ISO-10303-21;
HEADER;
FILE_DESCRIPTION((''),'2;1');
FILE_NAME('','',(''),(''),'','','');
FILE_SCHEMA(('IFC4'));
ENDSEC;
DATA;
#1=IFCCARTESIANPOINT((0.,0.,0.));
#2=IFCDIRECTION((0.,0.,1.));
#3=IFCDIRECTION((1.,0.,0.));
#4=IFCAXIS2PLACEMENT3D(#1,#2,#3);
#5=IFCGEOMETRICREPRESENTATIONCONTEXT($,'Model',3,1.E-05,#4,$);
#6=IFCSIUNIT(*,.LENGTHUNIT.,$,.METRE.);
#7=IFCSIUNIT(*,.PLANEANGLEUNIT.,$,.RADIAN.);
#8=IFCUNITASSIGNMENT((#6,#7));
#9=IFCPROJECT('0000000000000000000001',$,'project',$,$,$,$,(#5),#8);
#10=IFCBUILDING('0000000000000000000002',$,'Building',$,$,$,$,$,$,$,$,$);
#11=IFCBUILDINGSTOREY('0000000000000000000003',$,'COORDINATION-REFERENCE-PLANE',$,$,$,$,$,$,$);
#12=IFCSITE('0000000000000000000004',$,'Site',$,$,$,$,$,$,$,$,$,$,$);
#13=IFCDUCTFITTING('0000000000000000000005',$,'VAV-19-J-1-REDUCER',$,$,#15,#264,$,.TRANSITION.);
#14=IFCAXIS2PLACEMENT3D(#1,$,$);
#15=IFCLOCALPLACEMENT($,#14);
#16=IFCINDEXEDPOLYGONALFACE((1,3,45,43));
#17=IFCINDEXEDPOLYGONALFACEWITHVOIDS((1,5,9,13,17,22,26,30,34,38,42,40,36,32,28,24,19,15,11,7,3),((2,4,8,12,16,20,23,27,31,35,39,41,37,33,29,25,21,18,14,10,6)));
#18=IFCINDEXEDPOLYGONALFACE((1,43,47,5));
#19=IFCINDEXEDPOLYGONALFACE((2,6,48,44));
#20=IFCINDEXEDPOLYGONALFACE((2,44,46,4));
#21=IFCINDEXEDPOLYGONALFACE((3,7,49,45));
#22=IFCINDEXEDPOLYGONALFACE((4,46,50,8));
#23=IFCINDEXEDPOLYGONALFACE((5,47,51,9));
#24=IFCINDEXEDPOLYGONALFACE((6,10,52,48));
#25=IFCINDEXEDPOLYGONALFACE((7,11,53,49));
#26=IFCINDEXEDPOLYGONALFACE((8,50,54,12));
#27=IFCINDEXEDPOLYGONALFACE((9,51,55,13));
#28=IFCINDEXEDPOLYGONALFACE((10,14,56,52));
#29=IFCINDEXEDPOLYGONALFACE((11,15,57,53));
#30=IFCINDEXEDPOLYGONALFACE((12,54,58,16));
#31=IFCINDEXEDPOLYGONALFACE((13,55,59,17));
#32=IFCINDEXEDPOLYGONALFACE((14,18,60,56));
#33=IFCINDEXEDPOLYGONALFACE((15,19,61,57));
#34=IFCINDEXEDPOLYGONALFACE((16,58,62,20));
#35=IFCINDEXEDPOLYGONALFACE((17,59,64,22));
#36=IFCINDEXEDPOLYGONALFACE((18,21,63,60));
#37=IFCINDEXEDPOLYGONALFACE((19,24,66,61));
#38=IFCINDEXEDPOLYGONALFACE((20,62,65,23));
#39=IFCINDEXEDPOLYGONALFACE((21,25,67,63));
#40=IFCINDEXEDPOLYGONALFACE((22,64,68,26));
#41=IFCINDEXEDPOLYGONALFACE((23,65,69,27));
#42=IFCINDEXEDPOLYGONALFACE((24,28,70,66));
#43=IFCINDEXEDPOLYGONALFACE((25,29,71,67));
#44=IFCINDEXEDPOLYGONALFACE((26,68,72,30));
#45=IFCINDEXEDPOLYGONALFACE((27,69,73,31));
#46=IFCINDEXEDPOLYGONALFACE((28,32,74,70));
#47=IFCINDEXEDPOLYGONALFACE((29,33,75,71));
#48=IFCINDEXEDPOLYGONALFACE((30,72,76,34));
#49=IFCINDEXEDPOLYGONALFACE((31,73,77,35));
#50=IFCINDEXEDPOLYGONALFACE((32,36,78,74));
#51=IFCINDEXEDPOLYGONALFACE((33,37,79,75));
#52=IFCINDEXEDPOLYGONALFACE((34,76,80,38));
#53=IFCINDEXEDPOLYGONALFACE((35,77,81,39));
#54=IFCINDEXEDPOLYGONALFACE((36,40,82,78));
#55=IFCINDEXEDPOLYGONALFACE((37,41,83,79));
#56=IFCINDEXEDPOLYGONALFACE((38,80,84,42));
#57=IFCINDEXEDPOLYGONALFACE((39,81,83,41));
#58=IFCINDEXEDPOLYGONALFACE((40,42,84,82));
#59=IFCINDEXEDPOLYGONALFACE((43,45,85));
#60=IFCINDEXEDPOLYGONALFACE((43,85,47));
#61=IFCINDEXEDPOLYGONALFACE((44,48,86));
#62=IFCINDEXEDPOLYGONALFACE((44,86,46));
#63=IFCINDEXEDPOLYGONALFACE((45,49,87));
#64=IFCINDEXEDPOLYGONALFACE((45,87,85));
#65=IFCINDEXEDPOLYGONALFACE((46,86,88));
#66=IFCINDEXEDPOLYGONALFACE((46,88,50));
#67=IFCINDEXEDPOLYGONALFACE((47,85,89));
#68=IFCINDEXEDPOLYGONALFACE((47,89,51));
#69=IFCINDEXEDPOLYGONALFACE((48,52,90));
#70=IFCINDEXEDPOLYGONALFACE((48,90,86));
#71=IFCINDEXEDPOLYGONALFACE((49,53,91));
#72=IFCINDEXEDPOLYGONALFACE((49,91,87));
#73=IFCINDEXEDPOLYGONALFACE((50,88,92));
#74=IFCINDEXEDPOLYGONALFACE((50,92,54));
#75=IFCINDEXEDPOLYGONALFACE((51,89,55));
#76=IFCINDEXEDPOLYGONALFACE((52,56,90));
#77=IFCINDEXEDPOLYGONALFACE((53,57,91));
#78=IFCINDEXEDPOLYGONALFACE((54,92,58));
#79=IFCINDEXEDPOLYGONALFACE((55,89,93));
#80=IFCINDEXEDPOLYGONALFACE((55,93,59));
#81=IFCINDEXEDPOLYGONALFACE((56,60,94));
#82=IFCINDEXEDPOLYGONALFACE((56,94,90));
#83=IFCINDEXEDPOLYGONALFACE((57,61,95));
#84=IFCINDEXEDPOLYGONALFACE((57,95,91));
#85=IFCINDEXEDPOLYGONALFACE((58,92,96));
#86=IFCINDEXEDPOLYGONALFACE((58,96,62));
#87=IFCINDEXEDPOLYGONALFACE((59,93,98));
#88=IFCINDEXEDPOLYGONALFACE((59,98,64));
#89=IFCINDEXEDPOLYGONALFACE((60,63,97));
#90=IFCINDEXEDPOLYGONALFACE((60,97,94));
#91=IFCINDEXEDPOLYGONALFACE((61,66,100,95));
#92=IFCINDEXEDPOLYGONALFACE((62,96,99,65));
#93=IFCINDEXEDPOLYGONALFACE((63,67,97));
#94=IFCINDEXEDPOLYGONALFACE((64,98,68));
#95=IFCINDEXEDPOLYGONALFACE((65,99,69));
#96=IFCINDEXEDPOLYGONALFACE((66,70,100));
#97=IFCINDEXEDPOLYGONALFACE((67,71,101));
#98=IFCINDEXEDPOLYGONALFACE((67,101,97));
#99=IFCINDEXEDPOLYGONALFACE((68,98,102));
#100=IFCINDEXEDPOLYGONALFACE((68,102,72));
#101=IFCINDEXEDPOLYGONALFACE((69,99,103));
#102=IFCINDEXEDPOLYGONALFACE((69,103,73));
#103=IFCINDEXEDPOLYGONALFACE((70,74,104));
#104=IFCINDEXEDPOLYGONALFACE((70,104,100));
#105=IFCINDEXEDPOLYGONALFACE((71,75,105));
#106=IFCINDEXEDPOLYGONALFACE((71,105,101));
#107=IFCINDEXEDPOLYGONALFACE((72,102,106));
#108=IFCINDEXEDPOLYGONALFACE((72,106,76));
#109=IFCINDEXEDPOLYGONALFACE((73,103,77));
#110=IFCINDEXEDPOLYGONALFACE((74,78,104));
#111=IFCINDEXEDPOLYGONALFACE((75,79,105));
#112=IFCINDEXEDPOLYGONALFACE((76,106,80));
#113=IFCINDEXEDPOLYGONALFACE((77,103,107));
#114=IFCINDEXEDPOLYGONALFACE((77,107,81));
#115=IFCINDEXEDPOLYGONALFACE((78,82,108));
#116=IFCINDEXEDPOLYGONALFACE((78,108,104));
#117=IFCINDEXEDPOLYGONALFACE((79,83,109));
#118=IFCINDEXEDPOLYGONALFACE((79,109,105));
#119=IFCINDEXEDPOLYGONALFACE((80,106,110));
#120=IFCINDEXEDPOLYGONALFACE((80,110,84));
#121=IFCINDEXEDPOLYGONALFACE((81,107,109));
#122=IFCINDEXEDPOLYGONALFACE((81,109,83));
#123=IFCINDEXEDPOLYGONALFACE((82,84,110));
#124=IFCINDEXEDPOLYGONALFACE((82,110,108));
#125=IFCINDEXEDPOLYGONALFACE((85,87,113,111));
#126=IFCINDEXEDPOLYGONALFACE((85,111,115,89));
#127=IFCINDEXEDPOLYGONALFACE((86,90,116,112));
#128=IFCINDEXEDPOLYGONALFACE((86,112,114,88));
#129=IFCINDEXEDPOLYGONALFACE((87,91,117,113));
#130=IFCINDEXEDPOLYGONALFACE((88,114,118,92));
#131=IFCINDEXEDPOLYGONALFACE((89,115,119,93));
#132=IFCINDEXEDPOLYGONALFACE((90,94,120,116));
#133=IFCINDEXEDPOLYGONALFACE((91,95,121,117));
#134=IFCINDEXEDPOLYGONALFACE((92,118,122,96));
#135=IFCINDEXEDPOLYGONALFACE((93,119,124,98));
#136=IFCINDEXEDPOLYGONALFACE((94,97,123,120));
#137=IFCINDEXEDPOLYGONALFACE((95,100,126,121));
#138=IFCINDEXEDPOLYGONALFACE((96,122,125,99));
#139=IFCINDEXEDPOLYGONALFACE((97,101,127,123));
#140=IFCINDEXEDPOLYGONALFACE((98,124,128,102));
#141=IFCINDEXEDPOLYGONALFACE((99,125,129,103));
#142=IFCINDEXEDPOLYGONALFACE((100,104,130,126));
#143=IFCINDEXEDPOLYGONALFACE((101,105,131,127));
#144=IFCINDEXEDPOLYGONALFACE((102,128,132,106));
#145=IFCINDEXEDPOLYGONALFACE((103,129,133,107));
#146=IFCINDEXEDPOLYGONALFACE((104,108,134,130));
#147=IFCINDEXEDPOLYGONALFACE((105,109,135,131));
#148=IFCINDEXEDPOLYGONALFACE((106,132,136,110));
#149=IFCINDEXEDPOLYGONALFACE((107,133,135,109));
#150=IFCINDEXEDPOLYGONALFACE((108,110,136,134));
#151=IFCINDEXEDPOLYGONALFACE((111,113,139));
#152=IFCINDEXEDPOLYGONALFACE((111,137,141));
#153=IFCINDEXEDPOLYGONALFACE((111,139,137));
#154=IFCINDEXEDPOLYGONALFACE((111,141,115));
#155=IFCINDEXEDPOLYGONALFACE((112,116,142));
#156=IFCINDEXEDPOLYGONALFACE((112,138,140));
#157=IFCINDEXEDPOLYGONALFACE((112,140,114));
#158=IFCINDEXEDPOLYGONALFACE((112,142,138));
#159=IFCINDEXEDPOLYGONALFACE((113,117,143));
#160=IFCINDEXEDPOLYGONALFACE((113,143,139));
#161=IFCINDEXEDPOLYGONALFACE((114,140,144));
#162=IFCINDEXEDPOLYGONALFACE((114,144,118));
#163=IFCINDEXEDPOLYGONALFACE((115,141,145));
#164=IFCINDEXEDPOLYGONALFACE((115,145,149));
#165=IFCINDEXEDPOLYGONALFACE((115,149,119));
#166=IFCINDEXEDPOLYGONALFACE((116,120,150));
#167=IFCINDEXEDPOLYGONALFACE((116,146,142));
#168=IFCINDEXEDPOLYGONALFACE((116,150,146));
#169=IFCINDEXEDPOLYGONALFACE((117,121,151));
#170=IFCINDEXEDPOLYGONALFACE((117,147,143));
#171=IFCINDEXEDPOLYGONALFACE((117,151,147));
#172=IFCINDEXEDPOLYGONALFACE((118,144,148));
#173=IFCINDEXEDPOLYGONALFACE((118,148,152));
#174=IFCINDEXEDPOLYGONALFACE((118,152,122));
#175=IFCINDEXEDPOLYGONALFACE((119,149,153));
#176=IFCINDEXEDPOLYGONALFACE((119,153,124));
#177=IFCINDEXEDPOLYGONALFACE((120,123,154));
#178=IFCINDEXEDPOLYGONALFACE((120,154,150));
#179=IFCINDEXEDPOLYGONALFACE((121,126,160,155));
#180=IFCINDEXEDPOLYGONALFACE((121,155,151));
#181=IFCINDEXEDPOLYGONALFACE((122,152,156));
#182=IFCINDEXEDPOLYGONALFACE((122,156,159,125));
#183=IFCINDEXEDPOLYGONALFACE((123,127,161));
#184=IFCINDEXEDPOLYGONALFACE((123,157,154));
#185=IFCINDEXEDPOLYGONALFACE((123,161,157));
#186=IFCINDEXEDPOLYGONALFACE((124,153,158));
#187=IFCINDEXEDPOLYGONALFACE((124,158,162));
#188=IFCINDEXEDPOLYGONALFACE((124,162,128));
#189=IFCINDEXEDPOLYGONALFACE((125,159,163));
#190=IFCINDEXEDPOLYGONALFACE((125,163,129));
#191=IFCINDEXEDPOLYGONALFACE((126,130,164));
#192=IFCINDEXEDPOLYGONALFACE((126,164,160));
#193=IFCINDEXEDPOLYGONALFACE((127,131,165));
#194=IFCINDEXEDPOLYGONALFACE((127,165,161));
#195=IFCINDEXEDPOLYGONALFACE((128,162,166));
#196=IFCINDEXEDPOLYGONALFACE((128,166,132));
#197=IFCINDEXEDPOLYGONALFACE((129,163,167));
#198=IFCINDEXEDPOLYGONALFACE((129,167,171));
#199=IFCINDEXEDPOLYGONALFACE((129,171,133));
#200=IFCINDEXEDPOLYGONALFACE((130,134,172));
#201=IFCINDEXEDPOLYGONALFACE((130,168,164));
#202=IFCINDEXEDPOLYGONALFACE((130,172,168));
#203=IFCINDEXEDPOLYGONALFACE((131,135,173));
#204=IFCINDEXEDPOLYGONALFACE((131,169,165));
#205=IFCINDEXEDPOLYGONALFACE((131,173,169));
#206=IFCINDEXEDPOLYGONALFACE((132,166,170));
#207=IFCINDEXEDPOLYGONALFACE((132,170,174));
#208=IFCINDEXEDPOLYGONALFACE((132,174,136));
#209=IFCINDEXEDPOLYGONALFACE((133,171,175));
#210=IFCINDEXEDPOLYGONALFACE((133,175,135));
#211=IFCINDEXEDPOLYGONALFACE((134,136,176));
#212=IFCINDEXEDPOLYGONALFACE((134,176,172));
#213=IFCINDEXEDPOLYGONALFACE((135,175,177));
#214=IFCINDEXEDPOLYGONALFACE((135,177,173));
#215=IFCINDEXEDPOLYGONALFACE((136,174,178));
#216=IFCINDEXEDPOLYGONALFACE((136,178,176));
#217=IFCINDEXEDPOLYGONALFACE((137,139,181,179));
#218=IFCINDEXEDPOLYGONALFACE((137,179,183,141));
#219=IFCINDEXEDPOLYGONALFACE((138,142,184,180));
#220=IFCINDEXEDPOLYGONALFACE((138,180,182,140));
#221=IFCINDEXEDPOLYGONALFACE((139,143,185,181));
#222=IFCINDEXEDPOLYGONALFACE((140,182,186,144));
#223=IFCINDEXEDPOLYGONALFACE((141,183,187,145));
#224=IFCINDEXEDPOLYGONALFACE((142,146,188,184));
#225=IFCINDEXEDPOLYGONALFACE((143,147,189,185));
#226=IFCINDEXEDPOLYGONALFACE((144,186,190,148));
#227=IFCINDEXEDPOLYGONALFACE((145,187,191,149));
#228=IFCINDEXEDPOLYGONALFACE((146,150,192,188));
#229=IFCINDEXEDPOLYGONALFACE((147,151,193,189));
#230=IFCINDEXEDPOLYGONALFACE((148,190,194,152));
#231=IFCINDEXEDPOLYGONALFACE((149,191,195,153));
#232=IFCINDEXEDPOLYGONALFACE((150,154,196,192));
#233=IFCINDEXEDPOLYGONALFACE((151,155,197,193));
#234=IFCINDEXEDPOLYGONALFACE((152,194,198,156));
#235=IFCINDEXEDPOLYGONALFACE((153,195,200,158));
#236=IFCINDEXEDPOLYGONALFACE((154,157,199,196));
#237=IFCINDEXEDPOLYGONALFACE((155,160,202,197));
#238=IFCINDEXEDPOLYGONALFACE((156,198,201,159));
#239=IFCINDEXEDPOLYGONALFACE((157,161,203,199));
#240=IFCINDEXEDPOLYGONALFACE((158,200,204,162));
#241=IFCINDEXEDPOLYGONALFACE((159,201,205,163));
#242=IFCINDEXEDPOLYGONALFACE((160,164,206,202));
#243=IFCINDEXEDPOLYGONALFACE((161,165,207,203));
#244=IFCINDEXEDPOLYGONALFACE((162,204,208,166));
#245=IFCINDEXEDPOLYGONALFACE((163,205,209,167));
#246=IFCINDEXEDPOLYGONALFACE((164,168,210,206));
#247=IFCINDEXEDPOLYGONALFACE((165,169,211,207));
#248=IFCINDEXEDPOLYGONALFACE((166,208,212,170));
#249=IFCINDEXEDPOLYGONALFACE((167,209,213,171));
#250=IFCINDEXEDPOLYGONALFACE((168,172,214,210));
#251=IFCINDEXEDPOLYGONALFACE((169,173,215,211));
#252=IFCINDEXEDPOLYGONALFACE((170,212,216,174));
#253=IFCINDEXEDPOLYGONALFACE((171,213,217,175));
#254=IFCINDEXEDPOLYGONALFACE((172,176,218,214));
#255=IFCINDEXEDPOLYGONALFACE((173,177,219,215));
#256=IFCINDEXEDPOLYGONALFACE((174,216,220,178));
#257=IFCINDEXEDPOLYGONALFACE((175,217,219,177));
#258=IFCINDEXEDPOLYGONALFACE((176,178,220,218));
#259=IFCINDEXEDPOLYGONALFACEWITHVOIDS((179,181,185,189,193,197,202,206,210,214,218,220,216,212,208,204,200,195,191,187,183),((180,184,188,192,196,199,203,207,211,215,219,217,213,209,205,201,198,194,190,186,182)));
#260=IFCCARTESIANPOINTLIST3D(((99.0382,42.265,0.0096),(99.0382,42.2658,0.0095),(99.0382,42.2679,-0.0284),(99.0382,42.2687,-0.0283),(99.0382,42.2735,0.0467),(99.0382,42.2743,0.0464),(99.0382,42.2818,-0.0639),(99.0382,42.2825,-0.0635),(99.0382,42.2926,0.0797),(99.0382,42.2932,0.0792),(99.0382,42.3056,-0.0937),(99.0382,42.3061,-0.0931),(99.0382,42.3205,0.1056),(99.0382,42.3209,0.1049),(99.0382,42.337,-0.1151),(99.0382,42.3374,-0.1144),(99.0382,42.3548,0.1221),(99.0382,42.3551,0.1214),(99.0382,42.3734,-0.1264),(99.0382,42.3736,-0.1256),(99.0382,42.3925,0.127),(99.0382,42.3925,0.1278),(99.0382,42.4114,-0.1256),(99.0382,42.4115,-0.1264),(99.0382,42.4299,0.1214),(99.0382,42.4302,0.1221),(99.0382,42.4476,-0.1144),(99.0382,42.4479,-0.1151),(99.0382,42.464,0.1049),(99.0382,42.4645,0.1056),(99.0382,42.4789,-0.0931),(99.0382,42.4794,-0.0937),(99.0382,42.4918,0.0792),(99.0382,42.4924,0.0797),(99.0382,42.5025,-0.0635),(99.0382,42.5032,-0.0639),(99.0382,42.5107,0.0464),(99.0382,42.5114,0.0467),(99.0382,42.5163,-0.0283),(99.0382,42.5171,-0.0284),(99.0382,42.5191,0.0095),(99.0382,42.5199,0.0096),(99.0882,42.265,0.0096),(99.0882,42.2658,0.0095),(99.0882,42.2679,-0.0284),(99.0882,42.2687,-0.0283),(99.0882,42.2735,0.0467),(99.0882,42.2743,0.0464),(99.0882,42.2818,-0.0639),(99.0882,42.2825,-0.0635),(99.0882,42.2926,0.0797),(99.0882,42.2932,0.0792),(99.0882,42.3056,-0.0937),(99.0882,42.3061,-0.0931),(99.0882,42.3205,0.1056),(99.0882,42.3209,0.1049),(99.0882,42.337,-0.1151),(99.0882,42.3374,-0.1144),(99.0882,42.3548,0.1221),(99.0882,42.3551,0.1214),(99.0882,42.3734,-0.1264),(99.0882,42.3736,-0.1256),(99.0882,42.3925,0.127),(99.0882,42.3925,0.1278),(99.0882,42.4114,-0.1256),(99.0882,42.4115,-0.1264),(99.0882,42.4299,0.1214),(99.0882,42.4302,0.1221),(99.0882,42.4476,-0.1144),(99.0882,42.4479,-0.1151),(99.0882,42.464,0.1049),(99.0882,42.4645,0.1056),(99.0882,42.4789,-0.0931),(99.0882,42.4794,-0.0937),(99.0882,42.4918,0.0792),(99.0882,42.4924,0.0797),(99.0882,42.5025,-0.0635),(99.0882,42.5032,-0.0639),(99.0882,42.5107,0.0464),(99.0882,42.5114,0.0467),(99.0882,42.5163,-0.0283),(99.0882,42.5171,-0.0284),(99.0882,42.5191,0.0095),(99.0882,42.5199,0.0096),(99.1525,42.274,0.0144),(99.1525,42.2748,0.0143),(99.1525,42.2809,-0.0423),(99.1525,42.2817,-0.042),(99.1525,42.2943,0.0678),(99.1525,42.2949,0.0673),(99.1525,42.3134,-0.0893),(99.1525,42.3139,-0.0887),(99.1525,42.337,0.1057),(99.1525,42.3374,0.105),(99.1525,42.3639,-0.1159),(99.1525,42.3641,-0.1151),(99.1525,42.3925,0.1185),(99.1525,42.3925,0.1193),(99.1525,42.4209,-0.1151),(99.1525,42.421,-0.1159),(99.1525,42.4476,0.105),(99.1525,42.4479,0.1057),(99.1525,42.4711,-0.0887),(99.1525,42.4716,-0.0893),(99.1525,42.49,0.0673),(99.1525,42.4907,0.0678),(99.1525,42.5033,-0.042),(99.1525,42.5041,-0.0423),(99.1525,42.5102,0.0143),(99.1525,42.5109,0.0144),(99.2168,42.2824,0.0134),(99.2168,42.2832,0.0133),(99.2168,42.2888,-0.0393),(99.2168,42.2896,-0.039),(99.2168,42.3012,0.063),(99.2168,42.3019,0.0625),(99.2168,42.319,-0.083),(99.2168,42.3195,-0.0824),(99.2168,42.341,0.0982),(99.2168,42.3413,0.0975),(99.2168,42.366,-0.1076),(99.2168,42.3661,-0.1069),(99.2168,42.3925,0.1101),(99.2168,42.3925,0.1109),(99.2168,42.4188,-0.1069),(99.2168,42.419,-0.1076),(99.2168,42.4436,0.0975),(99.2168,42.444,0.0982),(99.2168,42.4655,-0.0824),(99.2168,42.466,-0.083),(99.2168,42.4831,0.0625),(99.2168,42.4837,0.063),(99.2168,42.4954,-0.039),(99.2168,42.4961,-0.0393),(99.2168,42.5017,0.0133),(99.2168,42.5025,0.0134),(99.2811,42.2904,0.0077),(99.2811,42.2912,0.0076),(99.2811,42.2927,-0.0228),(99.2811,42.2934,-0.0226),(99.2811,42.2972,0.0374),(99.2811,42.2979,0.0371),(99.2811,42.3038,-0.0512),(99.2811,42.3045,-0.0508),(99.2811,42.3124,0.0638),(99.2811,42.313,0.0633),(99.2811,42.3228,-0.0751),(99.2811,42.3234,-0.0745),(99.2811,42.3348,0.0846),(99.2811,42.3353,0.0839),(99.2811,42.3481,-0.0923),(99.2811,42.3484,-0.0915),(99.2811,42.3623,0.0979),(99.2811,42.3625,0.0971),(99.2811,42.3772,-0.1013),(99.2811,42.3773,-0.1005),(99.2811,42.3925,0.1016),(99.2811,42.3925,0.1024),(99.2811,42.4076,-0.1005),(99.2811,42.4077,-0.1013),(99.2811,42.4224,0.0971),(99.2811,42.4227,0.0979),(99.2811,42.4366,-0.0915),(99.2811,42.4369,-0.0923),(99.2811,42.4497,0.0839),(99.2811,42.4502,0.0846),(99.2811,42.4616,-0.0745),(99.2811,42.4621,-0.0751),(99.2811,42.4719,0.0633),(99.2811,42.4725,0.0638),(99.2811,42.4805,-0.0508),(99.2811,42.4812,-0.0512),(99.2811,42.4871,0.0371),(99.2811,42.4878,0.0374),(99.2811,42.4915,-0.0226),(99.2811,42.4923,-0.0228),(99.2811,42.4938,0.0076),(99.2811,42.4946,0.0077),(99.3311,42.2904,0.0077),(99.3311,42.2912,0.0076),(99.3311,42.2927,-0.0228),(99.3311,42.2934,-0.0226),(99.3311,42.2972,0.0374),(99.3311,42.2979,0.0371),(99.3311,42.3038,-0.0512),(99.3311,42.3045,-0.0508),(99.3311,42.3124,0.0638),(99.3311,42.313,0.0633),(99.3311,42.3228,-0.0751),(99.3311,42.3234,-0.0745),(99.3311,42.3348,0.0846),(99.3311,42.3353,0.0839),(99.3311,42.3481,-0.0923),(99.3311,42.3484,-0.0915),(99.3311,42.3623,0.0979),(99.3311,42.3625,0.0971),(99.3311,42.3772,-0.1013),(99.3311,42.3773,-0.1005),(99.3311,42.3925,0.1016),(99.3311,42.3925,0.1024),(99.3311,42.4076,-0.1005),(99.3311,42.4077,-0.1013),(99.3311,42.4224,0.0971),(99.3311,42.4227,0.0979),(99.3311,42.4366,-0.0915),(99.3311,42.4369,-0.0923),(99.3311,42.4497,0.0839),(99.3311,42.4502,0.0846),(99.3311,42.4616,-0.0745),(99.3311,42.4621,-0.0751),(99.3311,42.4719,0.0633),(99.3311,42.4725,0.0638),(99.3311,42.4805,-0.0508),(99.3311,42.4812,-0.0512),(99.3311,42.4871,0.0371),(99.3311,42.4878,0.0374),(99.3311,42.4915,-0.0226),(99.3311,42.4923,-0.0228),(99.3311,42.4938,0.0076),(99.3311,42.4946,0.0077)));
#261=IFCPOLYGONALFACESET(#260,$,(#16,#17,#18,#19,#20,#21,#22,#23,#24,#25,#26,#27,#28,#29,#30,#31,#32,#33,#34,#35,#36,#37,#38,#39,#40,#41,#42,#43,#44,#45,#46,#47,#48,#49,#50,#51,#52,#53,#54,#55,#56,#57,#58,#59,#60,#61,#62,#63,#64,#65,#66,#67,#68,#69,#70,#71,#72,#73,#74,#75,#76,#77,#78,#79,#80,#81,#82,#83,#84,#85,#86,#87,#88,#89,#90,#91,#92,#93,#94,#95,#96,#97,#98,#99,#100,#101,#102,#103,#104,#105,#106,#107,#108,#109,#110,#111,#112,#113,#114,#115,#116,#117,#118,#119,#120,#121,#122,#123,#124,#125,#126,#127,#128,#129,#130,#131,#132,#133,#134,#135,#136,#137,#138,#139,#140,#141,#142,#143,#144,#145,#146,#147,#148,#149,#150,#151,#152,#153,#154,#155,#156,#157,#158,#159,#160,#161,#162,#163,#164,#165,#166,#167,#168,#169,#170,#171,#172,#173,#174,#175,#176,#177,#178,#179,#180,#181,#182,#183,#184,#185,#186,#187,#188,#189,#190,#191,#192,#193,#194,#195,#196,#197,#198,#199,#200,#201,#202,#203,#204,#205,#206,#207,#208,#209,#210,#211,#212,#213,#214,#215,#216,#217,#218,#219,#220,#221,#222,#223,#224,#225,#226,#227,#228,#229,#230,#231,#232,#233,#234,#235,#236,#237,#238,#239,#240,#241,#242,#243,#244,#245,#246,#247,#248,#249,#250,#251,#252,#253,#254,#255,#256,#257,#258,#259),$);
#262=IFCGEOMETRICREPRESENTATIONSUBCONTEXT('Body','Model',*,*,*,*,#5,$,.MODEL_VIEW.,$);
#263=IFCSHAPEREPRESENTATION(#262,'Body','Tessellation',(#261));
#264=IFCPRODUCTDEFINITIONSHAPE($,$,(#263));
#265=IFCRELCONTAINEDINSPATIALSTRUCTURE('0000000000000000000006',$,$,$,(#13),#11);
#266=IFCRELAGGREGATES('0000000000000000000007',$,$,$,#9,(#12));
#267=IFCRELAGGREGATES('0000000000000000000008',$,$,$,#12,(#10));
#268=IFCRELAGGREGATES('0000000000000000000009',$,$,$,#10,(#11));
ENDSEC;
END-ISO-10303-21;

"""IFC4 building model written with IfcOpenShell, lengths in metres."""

from ifc_helpers import new_model, entity, si_unit, frame, origin_with_axes, place, context, subcontext, project, spatial, element, save


model = new_model("IFC4")

# Units and contexts
model_context_1 = context("Model", 3, precision=1e-05, world=origin_with_axes())
body_context_1 = subcontext(model_context_1, "Body", "Model", "MODEL_VIEW")
ifc_project = project(units=[si_unit("LENGTHUNIT", "METRE"), si_unit("PLANEANGLEUNIT", "RADIAN")], contexts=[model_context_1])

# Site, building, storey
site = spatial("IfcSite", under=ifc_project, Name="Site")
building = spatial("IfcBuilding", under=site, Name="Building")
storey = spatial("IfcBuildingStorey", under=building, Name="COORDINATION-REFERENCE-PLANE")

# Duct fitting
for number, where, z_axis, x_axis, name in (
    (1, (99.0382, 42.3925, 0.0), (0.0, 1.0, 0.0), (0.0, 0.0, 1.0), "VAV-19-J-1-REDUCER"),
):
    element("IfcDuctFitting", number, at=place(None, frame(where, z_axis=z_axis, x_axis=x_axis)), inside=storey, Name=name, PredefinedType="TRANSITION", context=body_context_1, shape_type="SweptSolid", body=[
        entity("IfcRevolvedAreaSolid", entity("IfcArbitraryClosedProfileDef", "AREA", None, entity("IfcPolyline", [entity("IfcCartesianPoint", [0.1278, 0.0]), entity("IfcCartesianPoint", [0.1278, 0.05]), entity("IfcCartesianPoint", [0.1024, 0.2429]), entity("IfcCartesianPoint", [0.1024, 0.2929]), entity("IfcCartesianPoint", [0.1016, 0.2929]), entity("IfcCartesianPoint", [0.1016, 0.2429]), entity("IfcCartesianPoint", [0.127, 0.05]), entity("IfcCartesianPoint", [0.127, 0.0]), entity("IfcCartesianPoint", [0.1278, 0.0])])), entity("IfcAxis2Placement3D", entity("IfcCartesianPoint", [0.0, 0.0, 0.0])), entity("IfcAxis1Placement", entity("IfcCartesianPoint", [0.0, 0.0, 0.0]), entity("IfcDirection", [0.0, 1.0, 0.0])), 6.283185),
    ])

save(model, "model.ifc")
